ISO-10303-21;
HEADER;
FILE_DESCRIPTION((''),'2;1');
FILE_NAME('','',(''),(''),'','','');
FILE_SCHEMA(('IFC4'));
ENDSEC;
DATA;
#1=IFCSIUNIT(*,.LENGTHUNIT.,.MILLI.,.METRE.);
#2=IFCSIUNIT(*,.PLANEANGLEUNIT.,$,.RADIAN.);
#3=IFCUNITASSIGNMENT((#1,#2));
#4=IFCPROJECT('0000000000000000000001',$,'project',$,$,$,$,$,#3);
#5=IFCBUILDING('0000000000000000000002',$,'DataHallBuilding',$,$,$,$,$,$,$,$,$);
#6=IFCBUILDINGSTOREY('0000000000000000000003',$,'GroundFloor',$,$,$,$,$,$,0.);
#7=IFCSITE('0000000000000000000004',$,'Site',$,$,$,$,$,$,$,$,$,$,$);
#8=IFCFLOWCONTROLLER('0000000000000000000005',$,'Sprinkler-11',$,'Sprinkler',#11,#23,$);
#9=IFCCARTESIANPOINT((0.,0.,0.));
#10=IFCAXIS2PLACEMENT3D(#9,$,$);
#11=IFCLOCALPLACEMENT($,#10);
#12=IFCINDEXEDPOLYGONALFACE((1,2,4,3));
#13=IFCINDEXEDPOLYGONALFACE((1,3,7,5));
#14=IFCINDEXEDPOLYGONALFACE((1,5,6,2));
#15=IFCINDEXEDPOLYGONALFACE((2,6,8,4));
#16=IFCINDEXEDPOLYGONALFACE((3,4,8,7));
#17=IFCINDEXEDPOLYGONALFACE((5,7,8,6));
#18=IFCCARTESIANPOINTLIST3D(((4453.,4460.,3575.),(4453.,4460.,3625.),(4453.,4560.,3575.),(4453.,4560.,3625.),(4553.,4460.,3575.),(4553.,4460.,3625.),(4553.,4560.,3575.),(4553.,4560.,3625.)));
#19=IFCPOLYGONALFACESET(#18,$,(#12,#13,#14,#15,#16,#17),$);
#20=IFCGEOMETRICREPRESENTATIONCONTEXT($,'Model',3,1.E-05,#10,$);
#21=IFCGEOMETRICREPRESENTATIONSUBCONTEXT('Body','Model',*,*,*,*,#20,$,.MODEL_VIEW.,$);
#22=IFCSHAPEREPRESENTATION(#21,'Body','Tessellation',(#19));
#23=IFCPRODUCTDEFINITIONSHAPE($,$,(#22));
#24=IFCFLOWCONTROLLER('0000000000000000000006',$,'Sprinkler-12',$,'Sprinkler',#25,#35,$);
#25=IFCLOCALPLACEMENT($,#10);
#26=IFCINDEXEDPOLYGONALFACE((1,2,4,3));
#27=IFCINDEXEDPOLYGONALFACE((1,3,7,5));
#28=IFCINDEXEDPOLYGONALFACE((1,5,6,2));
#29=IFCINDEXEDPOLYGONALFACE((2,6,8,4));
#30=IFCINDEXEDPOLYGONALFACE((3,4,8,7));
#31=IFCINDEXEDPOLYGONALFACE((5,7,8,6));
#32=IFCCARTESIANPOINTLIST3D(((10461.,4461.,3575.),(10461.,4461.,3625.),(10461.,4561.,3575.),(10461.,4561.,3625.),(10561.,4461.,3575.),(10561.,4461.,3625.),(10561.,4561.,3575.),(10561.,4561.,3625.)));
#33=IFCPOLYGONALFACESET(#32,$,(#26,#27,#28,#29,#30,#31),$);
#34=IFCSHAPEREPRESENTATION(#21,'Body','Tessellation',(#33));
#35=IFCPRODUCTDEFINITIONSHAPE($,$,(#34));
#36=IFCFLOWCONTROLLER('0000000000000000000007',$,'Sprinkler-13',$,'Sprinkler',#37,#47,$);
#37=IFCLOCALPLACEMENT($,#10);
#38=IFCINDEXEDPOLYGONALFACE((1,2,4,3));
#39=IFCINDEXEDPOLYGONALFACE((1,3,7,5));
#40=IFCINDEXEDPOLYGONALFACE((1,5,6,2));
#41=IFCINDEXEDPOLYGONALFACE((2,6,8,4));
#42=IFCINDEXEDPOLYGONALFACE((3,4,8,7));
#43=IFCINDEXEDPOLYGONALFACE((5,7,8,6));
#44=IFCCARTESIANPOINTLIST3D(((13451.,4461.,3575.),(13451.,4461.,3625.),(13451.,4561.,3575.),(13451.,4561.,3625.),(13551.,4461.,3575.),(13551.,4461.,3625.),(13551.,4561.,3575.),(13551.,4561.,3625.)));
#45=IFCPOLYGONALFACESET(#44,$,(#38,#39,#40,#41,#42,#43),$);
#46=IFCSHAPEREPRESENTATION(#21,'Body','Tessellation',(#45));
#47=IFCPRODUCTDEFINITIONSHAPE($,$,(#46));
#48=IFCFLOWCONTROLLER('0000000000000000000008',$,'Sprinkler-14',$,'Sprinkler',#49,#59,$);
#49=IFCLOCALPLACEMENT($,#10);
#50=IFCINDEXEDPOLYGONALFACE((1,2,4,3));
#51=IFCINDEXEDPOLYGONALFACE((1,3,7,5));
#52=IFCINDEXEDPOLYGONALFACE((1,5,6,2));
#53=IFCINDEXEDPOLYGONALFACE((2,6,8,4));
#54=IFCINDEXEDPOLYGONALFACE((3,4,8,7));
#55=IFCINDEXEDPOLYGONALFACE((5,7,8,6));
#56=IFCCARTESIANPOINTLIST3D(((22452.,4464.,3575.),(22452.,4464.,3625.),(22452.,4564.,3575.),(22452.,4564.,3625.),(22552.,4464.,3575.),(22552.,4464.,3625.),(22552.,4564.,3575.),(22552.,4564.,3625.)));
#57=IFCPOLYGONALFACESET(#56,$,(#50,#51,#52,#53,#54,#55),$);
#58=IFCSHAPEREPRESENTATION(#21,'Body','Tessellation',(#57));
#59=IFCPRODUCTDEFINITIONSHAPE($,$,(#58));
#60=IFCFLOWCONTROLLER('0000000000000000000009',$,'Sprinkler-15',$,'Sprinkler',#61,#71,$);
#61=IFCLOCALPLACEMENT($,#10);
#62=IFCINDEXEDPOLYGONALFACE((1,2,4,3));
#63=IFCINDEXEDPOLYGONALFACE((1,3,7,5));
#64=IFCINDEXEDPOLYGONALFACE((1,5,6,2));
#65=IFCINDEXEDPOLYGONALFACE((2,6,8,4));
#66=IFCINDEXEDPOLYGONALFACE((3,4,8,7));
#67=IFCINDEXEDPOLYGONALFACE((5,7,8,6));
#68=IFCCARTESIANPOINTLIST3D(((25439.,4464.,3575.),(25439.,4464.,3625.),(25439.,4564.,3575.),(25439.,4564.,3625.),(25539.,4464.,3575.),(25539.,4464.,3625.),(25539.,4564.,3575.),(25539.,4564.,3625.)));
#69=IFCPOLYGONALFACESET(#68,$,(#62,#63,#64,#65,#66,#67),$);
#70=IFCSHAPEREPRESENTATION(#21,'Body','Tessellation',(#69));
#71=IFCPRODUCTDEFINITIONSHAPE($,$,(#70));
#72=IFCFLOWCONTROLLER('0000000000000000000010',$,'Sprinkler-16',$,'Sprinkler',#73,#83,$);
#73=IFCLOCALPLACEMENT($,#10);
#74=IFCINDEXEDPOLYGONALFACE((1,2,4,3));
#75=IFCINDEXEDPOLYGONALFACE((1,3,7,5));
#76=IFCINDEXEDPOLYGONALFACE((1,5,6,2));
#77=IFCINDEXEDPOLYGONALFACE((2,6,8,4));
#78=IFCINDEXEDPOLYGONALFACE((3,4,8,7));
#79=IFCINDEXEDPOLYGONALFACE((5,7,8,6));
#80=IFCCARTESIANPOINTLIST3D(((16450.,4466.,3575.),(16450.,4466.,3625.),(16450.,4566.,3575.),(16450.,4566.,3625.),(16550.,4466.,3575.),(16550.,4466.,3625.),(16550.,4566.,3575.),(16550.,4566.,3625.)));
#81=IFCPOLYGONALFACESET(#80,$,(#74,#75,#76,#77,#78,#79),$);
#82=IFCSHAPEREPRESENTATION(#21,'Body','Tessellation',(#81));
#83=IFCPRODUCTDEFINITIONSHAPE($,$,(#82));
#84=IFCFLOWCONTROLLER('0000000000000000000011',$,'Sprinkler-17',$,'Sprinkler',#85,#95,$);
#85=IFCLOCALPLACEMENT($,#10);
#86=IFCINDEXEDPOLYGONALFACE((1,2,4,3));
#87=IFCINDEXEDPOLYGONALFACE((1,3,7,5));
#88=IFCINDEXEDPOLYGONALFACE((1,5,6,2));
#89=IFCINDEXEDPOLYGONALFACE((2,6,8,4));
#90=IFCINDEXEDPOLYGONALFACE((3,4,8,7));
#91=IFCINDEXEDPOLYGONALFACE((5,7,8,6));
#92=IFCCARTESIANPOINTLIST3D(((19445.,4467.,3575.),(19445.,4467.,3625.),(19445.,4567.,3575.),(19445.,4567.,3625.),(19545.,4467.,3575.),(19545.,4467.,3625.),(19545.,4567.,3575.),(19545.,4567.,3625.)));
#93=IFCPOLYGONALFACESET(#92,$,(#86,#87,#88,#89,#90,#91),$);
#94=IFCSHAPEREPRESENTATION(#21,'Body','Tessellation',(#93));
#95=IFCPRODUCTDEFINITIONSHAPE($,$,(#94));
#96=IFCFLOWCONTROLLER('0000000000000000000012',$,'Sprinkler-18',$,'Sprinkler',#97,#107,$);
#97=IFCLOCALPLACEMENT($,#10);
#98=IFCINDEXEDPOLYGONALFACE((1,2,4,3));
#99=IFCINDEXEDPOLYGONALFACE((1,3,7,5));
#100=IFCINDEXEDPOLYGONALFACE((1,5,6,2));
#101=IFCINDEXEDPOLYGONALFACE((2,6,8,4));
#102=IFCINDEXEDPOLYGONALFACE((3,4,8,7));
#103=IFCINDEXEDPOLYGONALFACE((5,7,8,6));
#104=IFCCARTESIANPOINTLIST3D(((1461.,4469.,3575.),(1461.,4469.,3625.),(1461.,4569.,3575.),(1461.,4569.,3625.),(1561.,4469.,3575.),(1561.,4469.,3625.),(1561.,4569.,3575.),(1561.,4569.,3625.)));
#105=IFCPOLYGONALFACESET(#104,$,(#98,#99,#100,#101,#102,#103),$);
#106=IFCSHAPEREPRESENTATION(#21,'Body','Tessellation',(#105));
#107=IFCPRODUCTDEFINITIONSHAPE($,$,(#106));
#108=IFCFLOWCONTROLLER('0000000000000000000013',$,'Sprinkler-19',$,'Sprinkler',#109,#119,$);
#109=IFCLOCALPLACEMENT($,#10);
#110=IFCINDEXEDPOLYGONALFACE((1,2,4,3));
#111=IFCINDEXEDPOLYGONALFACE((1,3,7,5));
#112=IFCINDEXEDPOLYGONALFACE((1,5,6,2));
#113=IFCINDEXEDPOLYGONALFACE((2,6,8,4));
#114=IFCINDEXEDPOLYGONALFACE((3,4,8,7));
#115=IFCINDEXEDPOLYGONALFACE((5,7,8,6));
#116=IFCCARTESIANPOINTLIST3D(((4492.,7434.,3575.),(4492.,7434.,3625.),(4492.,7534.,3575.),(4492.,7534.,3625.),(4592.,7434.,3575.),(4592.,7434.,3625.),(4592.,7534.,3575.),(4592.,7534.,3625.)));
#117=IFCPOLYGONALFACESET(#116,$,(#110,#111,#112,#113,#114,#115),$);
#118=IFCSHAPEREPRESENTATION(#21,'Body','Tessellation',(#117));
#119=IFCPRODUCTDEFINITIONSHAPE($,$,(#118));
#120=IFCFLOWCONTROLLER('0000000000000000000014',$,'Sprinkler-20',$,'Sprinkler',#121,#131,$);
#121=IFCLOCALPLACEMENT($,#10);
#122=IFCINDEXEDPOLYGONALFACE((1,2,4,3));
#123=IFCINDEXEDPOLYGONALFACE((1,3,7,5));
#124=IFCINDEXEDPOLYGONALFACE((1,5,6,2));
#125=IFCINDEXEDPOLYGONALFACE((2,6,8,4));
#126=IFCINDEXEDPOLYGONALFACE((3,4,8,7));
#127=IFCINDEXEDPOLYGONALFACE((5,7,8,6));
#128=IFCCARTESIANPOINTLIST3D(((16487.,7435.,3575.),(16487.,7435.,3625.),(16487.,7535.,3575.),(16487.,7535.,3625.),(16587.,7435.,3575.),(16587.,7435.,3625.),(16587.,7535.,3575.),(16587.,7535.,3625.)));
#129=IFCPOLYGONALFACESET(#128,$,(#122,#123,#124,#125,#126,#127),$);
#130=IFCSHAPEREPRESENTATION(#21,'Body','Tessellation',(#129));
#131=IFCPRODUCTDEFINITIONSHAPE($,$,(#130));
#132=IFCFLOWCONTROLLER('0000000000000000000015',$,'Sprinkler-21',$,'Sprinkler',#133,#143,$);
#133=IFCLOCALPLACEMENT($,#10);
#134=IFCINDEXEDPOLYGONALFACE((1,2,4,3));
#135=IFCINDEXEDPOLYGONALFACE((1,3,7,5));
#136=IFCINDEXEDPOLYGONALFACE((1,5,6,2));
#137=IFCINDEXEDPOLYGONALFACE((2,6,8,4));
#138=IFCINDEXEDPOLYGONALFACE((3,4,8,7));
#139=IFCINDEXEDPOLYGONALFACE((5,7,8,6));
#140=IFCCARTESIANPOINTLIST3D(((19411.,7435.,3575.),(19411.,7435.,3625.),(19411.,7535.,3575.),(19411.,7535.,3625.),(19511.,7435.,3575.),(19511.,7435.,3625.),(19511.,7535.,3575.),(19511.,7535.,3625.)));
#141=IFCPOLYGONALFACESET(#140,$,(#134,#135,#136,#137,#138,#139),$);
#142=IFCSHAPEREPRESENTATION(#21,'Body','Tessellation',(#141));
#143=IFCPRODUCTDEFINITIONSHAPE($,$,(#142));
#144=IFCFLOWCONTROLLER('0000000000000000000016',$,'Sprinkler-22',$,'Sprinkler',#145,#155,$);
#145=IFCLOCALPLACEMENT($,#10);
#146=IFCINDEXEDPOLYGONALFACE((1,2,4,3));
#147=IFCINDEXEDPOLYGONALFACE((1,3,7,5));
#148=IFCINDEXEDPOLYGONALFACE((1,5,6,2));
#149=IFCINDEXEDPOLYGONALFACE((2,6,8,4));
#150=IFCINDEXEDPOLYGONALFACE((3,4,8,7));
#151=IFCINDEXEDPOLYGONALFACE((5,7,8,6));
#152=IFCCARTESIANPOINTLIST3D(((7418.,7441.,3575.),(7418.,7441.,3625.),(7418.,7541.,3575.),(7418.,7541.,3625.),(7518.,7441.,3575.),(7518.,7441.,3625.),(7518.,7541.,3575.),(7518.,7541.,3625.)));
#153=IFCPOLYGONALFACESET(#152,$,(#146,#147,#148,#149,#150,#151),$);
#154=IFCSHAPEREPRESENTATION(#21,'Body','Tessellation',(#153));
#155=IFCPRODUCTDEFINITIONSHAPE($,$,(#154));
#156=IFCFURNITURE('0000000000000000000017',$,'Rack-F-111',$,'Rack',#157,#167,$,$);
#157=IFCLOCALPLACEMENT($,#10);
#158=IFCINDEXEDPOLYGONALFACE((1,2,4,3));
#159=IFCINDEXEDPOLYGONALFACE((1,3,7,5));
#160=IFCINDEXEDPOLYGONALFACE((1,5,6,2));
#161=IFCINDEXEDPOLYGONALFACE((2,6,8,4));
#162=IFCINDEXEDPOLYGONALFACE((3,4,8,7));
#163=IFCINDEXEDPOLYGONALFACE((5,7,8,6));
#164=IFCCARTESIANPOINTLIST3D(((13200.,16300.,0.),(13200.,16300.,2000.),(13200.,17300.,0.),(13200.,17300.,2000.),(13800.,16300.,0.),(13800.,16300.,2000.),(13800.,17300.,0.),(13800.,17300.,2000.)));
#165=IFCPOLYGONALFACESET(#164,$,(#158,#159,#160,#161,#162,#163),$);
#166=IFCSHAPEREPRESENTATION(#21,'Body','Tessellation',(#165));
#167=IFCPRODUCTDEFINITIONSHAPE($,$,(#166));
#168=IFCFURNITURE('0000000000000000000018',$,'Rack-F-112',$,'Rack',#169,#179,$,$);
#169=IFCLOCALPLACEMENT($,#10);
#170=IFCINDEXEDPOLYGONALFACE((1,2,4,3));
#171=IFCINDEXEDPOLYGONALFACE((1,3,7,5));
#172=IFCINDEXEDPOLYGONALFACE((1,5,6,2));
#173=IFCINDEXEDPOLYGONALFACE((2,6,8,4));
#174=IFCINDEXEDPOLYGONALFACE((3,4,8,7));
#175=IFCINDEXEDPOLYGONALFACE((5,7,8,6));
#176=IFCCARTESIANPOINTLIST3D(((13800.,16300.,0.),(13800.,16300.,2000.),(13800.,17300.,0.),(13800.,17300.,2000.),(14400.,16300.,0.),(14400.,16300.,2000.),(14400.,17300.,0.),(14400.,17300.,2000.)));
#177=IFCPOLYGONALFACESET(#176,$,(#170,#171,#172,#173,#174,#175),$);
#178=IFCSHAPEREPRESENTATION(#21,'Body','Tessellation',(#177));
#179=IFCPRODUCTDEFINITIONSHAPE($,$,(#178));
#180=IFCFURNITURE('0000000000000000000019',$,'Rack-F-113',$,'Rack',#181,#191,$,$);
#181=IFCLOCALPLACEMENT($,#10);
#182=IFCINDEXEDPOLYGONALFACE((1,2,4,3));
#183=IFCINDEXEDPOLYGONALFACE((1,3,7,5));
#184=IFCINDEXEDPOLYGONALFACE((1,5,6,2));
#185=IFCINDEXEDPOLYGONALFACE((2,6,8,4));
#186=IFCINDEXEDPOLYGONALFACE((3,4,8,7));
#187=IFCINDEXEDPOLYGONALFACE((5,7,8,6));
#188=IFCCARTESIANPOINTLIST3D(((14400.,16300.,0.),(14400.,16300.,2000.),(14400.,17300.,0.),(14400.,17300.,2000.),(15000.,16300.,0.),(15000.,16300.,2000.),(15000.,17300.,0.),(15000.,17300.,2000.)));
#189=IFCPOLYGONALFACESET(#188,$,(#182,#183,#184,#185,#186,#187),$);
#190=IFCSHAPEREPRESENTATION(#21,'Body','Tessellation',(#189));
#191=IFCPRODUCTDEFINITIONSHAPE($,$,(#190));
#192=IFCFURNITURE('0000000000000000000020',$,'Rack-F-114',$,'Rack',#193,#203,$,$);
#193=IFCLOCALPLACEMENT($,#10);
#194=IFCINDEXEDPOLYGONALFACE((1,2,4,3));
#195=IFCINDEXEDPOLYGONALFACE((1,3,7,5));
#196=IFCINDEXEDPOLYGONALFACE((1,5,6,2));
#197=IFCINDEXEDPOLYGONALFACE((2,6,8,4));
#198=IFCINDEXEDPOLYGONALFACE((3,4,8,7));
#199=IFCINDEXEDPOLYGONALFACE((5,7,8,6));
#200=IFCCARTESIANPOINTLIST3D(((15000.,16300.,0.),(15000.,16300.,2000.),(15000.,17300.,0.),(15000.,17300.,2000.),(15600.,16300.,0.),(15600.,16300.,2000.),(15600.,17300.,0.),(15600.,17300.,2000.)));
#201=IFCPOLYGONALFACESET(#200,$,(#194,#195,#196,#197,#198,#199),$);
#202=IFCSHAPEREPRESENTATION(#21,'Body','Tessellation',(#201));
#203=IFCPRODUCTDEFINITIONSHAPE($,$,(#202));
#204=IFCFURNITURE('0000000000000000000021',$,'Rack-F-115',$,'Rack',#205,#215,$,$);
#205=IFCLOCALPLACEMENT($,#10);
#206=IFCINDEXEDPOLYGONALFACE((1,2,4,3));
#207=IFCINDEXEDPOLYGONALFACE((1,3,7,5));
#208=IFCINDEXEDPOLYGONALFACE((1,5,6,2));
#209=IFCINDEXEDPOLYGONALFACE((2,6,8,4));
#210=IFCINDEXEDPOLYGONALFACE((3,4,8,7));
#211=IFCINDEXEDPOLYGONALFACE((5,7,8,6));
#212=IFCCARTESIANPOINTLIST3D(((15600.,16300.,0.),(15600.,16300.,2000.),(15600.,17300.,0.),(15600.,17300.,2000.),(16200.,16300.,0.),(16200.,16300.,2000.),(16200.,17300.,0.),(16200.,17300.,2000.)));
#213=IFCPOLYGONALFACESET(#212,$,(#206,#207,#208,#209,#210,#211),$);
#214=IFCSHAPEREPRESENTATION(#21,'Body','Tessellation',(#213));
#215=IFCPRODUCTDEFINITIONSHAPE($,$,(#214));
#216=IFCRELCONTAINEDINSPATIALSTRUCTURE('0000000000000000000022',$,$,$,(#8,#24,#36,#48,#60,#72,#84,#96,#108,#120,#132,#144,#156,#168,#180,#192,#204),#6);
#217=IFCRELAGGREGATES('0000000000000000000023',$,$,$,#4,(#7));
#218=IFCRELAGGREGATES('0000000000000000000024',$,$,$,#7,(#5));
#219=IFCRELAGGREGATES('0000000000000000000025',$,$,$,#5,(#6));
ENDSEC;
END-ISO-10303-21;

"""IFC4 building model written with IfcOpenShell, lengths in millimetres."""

from ifc_helpers import new_model, si_unit, frame, origin, place, context, subcontext, project, spatial, rectangle, extrude, element, save


model = new_model("IFC4")

# Units and contexts
model_context = context("Model", 3, precision=1e-05, world=origin())
body_context = subcontext(model_context, "Body", "Model", "MODEL_VIEW")
ifc_project = project(units=[si_unit("LENGTHUNIT", "METRE", prefix="MILLI"), si_unit("PLANEANGLEUNIT", "RADIAN")])

# Site, building, storey
site = spatial("IfcSite", under=ifc_project, Name="Site")
building = spatial("IfcBuilding", under=site, Name="DataHallBuilding")
storey = spatial("IfcBuildingStorey", under=building, Name="GroundFloor", Elevation=0.0)

# Flow controllers
flow_controller_1_placement = place(None, origin())
element("IfcFlowController", 1, at=flow_controller_1_placement, inside=storey, Name="Sprinkler-11", ObjectType="Sprinkler", context=body_context, shape_type="SweptSolid", body=[
    extrude(rectangle(XDim=100.0, YDim=100.0), frame((4503.0, 4510.0, 3575.0), z_axis=(0.0, 0.0, 1.0), x_axis=(1.0, 0.0, 0.0)), (0.0, 0.0, 1.0), 50.0),
])
flow_controller_2_placement = place(None, origin())
element("IfcFlowController", 2, at=flow_controller_2_placement, inside=storey, Name="Sprinkler-12", ObjectType="Sprinkler", context=body_context, shape_type="SweptSolid", body=[
    extrude(rectangle(XDim=100.0, YDim=100.0), frame((10511.0, 4511.0, 3575.0), z_axis=(0.0, 0.0, 1.0), x_axis=(1.0, 0.0, 0.0)), (0.0, 0.0, 1.0), 50.0),
])
flow_controller_3_placement = place(None, origin())
element("IfcFlowController", 3, at=flow_controller_3_placement, inside=storey, Name="Sprinkler-13", ObjectType="Sprinkler", context=body_context, shape_type="SweptSolid", body=[
    extrude(rectangle(XDim=100.0, YDim=100.0), frame((13501.0, 4511.0, 3575.0), z_axis=(0.0, 0.0, 1.0), x_axis=(1.0, 0.0, 0.0)), (0.0, 0.0, 1.0), 50.0),
])
flow_controller_4_placement = place(None, origin())
element("IfcFlowController", 4, at=flow_controller_4_placement, inside=storey, Name="Sprinkler-14", ObjectType="Sprinkler", context=body_context, shape_type="SweptSolid", body=[
    extrude(rectangle(XDim=100.0, YDim=100.0), frame((22502.0, 4514.0, 3575.0), z_axis=(0.0, 0.0, 1.0), x_axis=(1.0, 0.0, 0.0)), (0.0, 0.0, 1.0), 50.0),
])
flow_controller_5_placement = place(None, origin())
element("IfcFlowController", 5, at=flow_controller_5_placement, inside=storey, Name="Sprinkler-15", ObjectType="Sprinkler", context=body_context, shape_type="SweptSolid", body=[
    extrude(rectangle(XDim=100.0, YDim=100.0), frame((25489.0, 4514.0, 3575.0), z_axis=(0.0, 0.0, 1.0), x_axis=(1.0, 0.0, 0.0)), (0.0, 0.0, 1.0), 50.0),
])
flow_controller_6_placement = place(None, origin())
element("IfcFlowController", 6, at=flow_controller_6_placement, inside=storey, Name="Sprinkler-16", ObjectType="Sprinkler", context=body_context, shape_type="SweptSolid", body=[
    extrude(rectangle(XDim=100.0, YDim=100.0), frame((16500.0, 4516.0, 3575.0), z_axis=(0.0, 0.0, 1.0), x_axis=(1.0, 0.0, 0.0)), (0.0, 0.0, 1.0), 50.0),
])
flow_controller_7_placement = place(None, origin())
element("IfcFlowController", 7, at=flow_controller_7_placement, inside=storey, Name="Sprinkler-17", ObjectType="Sprinkler", context=body_context, shape_type="SweptSolid", body=[
    extrude(rectangle(XDim=100.0, YDim=100.0), frame((19495.0, 4517.0, 3575.0), z_axis=(0.0, 0.0, 1.0), x_axis=(1.0, 0.0, 0.0)), (0.0, 0.0, 1.0), 50.0),
])
flow_controller_8_placement = place(None, origin())
element("IfcFlowController", 8, at=flow_controller_8_placement, inside=storey, Name="Sprinkler-18", ObjectType="Sprinkler", context=body_context, shape_type="SweptSolid", body=[
    extrude(rectangle(XDim=100.0, YDim=100.0), frame((1511.0, 4519.0, 3575.0), z_axis=(0.0, 0.0, 1.0), x_axis=(1.0, 0.0, 0.0)), (0.0, 0.0, 1.0), 50.0),
])
flow_controller_9_placement = place(None, origin())
element("IfcFlowController", 9, at=flow_controller_9_placement, inside=storey, Name="Sprinkler-19", ObjectType="Sprinkler", context=body_context, shape_type="SweptSolid", body=[
    extrude(rectangle(XDim=100.0, YDim=100.0), frame((4542.0, 7484.0, 3575.0), z_axis=(0.0, 0.0, 1.0), x_axis=(1.0, 0.0, 0.0)), (0.0, 0.0, 1.0), 50.0),
])
flow_controller_10_placement = place(None, origin())
element("IfcFlowController", 10, at=flow_controller_10_placement, inside=storey, Name="Sprinkler-20", ObjectType="Sprinkler", context=body_context, shape_type="SweptSolid", body=[
    extrude(rectangle(XDim=100.0, YDim=100.0), frame((16537.0, 7485.0, 3575.0), z_axis=(0.0, 0.0, 1.0), x_axis=(1.0, 0.0, 0.0)), (0.0, 0.0, 1.0), 50.0),
])
flow_controller_11_placement = place(None, origin())
element("IfcFlowController", 11, at=flow_controller_11_placement, inside=storey, Name="Sprinkler-21", ObjectType="Sprinkler", context=body_context, shape_type="SweptSolid", body=[
    extrude(rectangle(XDim=100.0, YDim=100.0), frame((19461.0, 7485.0, 3575.0), z_axis=(0.0, 0.0, 1.0), x_axis=(1.0, 0.0, 0.0)), (0.0, 0.0, 1.0), 50.0),
])
flow_controller_12_placement = place(None, origin())
element("IfcFlowController", 12, at=flow_controller_12_placement, inside=storey, Name="Sprinkler-22", ObjectType="Sprinkler", context=body_context, shape_type="SweptSolid", body=[
    extrude(rectangle(XDim=100.0, YDim=100.0), frame((7468.0, 7491.0, 3575.0), z_axis=(0.0, 0.0, 1.0), x_axis=(1.0, 0.0, 0.0)), (0.0, 0.0, 1.0), 50.0),
])

# Furniture
furniture_1_placement = place(None, origin())
element("IfcFurniture", 13, at=furniture_1_placement, inside=storey, Name="Rack-F-111", ObjectType="Rack", context=body_context, shape_type="SweptSolid", body=[
    extrude(rectangle(XDim=600.0, YDim=1000.0), frame((13500.0, 16800.0, 0.0), z_axis=(0.0, 0.0, 1.0), x_axis=(1.0, 0.0, 0.0)), (0.0, 0.0, 1.0), 2000.0),
])
furniture_2_placement = place(None, origin())
element("IfcFurniture", 14, at=furniture_2_placement, inside=storey, Name="Rack-F-112", ObjectType="Rack", context=body_context, shape_type="SweptSolid", body=[
    extrude(rectangle(XDim=600.0, YDim=1000.0), frame((14100.0, 16800.0, 0.0), z_axis=(0.0, 0.0, 1.0), x_axis=(1.0, 0.0, 0.0)), (0.0, 0.0, 1.0), 2000.0),
])
furniture_3_placement = place(None, origin())
element("IfcFurniture", 15, at=furniture_3_placement, inside=storey, Name="Rack-F-113", ObjectType="Rack", context=body_context, shape_type="SweptSolid", body=[
    extrude(rectangle(XDim=600.0, YDim=1000.0), frame((14700.0, 16800.0, 0.0), z_axis=(0.0, 0.0, 1.0), x_axis=(1.0, 0.0, 0.0)), (0.0, 0.0, 1.0), 2000.0),
])
furniture_4_placement = place(None, origin())
element("IfcFurniture", 16, at=furniture_4_placement, inside=storey, Name="Rack-F-114", ObjectType="Rack", context=body_context, shape_type="SweptSolid", body=[
    extrude(rectangle(XDim=600.0, YDim=1000.0), frame((15300.0, 16800.0, 0.0), z_axis=(0.0, 0.0, 1.0), x_axis=(1.0, 0.0, 0.0)), (0.0, 0.0, 1.0), 2000.0),
])
furniture_5_placement = place(None, origin())
element("IfcFurniture", 17, at=furniture_5_placement, inside=storey, Name="Rack-F-115", ObjectType="Rack", context=body_context, shape_type="SweptSolid", body=[
    extrude(rectangle(XDim=600.0, YDim=1000.0), frame((15900.0, 16800.0, 0.0), z_axis=(0.0, 0.0, 1.0), x_axis=(1.0, 0.0, 0.0)), (0.0, 0.0, 1.0), 2000.0),
])

save(model, "model.ifc")
